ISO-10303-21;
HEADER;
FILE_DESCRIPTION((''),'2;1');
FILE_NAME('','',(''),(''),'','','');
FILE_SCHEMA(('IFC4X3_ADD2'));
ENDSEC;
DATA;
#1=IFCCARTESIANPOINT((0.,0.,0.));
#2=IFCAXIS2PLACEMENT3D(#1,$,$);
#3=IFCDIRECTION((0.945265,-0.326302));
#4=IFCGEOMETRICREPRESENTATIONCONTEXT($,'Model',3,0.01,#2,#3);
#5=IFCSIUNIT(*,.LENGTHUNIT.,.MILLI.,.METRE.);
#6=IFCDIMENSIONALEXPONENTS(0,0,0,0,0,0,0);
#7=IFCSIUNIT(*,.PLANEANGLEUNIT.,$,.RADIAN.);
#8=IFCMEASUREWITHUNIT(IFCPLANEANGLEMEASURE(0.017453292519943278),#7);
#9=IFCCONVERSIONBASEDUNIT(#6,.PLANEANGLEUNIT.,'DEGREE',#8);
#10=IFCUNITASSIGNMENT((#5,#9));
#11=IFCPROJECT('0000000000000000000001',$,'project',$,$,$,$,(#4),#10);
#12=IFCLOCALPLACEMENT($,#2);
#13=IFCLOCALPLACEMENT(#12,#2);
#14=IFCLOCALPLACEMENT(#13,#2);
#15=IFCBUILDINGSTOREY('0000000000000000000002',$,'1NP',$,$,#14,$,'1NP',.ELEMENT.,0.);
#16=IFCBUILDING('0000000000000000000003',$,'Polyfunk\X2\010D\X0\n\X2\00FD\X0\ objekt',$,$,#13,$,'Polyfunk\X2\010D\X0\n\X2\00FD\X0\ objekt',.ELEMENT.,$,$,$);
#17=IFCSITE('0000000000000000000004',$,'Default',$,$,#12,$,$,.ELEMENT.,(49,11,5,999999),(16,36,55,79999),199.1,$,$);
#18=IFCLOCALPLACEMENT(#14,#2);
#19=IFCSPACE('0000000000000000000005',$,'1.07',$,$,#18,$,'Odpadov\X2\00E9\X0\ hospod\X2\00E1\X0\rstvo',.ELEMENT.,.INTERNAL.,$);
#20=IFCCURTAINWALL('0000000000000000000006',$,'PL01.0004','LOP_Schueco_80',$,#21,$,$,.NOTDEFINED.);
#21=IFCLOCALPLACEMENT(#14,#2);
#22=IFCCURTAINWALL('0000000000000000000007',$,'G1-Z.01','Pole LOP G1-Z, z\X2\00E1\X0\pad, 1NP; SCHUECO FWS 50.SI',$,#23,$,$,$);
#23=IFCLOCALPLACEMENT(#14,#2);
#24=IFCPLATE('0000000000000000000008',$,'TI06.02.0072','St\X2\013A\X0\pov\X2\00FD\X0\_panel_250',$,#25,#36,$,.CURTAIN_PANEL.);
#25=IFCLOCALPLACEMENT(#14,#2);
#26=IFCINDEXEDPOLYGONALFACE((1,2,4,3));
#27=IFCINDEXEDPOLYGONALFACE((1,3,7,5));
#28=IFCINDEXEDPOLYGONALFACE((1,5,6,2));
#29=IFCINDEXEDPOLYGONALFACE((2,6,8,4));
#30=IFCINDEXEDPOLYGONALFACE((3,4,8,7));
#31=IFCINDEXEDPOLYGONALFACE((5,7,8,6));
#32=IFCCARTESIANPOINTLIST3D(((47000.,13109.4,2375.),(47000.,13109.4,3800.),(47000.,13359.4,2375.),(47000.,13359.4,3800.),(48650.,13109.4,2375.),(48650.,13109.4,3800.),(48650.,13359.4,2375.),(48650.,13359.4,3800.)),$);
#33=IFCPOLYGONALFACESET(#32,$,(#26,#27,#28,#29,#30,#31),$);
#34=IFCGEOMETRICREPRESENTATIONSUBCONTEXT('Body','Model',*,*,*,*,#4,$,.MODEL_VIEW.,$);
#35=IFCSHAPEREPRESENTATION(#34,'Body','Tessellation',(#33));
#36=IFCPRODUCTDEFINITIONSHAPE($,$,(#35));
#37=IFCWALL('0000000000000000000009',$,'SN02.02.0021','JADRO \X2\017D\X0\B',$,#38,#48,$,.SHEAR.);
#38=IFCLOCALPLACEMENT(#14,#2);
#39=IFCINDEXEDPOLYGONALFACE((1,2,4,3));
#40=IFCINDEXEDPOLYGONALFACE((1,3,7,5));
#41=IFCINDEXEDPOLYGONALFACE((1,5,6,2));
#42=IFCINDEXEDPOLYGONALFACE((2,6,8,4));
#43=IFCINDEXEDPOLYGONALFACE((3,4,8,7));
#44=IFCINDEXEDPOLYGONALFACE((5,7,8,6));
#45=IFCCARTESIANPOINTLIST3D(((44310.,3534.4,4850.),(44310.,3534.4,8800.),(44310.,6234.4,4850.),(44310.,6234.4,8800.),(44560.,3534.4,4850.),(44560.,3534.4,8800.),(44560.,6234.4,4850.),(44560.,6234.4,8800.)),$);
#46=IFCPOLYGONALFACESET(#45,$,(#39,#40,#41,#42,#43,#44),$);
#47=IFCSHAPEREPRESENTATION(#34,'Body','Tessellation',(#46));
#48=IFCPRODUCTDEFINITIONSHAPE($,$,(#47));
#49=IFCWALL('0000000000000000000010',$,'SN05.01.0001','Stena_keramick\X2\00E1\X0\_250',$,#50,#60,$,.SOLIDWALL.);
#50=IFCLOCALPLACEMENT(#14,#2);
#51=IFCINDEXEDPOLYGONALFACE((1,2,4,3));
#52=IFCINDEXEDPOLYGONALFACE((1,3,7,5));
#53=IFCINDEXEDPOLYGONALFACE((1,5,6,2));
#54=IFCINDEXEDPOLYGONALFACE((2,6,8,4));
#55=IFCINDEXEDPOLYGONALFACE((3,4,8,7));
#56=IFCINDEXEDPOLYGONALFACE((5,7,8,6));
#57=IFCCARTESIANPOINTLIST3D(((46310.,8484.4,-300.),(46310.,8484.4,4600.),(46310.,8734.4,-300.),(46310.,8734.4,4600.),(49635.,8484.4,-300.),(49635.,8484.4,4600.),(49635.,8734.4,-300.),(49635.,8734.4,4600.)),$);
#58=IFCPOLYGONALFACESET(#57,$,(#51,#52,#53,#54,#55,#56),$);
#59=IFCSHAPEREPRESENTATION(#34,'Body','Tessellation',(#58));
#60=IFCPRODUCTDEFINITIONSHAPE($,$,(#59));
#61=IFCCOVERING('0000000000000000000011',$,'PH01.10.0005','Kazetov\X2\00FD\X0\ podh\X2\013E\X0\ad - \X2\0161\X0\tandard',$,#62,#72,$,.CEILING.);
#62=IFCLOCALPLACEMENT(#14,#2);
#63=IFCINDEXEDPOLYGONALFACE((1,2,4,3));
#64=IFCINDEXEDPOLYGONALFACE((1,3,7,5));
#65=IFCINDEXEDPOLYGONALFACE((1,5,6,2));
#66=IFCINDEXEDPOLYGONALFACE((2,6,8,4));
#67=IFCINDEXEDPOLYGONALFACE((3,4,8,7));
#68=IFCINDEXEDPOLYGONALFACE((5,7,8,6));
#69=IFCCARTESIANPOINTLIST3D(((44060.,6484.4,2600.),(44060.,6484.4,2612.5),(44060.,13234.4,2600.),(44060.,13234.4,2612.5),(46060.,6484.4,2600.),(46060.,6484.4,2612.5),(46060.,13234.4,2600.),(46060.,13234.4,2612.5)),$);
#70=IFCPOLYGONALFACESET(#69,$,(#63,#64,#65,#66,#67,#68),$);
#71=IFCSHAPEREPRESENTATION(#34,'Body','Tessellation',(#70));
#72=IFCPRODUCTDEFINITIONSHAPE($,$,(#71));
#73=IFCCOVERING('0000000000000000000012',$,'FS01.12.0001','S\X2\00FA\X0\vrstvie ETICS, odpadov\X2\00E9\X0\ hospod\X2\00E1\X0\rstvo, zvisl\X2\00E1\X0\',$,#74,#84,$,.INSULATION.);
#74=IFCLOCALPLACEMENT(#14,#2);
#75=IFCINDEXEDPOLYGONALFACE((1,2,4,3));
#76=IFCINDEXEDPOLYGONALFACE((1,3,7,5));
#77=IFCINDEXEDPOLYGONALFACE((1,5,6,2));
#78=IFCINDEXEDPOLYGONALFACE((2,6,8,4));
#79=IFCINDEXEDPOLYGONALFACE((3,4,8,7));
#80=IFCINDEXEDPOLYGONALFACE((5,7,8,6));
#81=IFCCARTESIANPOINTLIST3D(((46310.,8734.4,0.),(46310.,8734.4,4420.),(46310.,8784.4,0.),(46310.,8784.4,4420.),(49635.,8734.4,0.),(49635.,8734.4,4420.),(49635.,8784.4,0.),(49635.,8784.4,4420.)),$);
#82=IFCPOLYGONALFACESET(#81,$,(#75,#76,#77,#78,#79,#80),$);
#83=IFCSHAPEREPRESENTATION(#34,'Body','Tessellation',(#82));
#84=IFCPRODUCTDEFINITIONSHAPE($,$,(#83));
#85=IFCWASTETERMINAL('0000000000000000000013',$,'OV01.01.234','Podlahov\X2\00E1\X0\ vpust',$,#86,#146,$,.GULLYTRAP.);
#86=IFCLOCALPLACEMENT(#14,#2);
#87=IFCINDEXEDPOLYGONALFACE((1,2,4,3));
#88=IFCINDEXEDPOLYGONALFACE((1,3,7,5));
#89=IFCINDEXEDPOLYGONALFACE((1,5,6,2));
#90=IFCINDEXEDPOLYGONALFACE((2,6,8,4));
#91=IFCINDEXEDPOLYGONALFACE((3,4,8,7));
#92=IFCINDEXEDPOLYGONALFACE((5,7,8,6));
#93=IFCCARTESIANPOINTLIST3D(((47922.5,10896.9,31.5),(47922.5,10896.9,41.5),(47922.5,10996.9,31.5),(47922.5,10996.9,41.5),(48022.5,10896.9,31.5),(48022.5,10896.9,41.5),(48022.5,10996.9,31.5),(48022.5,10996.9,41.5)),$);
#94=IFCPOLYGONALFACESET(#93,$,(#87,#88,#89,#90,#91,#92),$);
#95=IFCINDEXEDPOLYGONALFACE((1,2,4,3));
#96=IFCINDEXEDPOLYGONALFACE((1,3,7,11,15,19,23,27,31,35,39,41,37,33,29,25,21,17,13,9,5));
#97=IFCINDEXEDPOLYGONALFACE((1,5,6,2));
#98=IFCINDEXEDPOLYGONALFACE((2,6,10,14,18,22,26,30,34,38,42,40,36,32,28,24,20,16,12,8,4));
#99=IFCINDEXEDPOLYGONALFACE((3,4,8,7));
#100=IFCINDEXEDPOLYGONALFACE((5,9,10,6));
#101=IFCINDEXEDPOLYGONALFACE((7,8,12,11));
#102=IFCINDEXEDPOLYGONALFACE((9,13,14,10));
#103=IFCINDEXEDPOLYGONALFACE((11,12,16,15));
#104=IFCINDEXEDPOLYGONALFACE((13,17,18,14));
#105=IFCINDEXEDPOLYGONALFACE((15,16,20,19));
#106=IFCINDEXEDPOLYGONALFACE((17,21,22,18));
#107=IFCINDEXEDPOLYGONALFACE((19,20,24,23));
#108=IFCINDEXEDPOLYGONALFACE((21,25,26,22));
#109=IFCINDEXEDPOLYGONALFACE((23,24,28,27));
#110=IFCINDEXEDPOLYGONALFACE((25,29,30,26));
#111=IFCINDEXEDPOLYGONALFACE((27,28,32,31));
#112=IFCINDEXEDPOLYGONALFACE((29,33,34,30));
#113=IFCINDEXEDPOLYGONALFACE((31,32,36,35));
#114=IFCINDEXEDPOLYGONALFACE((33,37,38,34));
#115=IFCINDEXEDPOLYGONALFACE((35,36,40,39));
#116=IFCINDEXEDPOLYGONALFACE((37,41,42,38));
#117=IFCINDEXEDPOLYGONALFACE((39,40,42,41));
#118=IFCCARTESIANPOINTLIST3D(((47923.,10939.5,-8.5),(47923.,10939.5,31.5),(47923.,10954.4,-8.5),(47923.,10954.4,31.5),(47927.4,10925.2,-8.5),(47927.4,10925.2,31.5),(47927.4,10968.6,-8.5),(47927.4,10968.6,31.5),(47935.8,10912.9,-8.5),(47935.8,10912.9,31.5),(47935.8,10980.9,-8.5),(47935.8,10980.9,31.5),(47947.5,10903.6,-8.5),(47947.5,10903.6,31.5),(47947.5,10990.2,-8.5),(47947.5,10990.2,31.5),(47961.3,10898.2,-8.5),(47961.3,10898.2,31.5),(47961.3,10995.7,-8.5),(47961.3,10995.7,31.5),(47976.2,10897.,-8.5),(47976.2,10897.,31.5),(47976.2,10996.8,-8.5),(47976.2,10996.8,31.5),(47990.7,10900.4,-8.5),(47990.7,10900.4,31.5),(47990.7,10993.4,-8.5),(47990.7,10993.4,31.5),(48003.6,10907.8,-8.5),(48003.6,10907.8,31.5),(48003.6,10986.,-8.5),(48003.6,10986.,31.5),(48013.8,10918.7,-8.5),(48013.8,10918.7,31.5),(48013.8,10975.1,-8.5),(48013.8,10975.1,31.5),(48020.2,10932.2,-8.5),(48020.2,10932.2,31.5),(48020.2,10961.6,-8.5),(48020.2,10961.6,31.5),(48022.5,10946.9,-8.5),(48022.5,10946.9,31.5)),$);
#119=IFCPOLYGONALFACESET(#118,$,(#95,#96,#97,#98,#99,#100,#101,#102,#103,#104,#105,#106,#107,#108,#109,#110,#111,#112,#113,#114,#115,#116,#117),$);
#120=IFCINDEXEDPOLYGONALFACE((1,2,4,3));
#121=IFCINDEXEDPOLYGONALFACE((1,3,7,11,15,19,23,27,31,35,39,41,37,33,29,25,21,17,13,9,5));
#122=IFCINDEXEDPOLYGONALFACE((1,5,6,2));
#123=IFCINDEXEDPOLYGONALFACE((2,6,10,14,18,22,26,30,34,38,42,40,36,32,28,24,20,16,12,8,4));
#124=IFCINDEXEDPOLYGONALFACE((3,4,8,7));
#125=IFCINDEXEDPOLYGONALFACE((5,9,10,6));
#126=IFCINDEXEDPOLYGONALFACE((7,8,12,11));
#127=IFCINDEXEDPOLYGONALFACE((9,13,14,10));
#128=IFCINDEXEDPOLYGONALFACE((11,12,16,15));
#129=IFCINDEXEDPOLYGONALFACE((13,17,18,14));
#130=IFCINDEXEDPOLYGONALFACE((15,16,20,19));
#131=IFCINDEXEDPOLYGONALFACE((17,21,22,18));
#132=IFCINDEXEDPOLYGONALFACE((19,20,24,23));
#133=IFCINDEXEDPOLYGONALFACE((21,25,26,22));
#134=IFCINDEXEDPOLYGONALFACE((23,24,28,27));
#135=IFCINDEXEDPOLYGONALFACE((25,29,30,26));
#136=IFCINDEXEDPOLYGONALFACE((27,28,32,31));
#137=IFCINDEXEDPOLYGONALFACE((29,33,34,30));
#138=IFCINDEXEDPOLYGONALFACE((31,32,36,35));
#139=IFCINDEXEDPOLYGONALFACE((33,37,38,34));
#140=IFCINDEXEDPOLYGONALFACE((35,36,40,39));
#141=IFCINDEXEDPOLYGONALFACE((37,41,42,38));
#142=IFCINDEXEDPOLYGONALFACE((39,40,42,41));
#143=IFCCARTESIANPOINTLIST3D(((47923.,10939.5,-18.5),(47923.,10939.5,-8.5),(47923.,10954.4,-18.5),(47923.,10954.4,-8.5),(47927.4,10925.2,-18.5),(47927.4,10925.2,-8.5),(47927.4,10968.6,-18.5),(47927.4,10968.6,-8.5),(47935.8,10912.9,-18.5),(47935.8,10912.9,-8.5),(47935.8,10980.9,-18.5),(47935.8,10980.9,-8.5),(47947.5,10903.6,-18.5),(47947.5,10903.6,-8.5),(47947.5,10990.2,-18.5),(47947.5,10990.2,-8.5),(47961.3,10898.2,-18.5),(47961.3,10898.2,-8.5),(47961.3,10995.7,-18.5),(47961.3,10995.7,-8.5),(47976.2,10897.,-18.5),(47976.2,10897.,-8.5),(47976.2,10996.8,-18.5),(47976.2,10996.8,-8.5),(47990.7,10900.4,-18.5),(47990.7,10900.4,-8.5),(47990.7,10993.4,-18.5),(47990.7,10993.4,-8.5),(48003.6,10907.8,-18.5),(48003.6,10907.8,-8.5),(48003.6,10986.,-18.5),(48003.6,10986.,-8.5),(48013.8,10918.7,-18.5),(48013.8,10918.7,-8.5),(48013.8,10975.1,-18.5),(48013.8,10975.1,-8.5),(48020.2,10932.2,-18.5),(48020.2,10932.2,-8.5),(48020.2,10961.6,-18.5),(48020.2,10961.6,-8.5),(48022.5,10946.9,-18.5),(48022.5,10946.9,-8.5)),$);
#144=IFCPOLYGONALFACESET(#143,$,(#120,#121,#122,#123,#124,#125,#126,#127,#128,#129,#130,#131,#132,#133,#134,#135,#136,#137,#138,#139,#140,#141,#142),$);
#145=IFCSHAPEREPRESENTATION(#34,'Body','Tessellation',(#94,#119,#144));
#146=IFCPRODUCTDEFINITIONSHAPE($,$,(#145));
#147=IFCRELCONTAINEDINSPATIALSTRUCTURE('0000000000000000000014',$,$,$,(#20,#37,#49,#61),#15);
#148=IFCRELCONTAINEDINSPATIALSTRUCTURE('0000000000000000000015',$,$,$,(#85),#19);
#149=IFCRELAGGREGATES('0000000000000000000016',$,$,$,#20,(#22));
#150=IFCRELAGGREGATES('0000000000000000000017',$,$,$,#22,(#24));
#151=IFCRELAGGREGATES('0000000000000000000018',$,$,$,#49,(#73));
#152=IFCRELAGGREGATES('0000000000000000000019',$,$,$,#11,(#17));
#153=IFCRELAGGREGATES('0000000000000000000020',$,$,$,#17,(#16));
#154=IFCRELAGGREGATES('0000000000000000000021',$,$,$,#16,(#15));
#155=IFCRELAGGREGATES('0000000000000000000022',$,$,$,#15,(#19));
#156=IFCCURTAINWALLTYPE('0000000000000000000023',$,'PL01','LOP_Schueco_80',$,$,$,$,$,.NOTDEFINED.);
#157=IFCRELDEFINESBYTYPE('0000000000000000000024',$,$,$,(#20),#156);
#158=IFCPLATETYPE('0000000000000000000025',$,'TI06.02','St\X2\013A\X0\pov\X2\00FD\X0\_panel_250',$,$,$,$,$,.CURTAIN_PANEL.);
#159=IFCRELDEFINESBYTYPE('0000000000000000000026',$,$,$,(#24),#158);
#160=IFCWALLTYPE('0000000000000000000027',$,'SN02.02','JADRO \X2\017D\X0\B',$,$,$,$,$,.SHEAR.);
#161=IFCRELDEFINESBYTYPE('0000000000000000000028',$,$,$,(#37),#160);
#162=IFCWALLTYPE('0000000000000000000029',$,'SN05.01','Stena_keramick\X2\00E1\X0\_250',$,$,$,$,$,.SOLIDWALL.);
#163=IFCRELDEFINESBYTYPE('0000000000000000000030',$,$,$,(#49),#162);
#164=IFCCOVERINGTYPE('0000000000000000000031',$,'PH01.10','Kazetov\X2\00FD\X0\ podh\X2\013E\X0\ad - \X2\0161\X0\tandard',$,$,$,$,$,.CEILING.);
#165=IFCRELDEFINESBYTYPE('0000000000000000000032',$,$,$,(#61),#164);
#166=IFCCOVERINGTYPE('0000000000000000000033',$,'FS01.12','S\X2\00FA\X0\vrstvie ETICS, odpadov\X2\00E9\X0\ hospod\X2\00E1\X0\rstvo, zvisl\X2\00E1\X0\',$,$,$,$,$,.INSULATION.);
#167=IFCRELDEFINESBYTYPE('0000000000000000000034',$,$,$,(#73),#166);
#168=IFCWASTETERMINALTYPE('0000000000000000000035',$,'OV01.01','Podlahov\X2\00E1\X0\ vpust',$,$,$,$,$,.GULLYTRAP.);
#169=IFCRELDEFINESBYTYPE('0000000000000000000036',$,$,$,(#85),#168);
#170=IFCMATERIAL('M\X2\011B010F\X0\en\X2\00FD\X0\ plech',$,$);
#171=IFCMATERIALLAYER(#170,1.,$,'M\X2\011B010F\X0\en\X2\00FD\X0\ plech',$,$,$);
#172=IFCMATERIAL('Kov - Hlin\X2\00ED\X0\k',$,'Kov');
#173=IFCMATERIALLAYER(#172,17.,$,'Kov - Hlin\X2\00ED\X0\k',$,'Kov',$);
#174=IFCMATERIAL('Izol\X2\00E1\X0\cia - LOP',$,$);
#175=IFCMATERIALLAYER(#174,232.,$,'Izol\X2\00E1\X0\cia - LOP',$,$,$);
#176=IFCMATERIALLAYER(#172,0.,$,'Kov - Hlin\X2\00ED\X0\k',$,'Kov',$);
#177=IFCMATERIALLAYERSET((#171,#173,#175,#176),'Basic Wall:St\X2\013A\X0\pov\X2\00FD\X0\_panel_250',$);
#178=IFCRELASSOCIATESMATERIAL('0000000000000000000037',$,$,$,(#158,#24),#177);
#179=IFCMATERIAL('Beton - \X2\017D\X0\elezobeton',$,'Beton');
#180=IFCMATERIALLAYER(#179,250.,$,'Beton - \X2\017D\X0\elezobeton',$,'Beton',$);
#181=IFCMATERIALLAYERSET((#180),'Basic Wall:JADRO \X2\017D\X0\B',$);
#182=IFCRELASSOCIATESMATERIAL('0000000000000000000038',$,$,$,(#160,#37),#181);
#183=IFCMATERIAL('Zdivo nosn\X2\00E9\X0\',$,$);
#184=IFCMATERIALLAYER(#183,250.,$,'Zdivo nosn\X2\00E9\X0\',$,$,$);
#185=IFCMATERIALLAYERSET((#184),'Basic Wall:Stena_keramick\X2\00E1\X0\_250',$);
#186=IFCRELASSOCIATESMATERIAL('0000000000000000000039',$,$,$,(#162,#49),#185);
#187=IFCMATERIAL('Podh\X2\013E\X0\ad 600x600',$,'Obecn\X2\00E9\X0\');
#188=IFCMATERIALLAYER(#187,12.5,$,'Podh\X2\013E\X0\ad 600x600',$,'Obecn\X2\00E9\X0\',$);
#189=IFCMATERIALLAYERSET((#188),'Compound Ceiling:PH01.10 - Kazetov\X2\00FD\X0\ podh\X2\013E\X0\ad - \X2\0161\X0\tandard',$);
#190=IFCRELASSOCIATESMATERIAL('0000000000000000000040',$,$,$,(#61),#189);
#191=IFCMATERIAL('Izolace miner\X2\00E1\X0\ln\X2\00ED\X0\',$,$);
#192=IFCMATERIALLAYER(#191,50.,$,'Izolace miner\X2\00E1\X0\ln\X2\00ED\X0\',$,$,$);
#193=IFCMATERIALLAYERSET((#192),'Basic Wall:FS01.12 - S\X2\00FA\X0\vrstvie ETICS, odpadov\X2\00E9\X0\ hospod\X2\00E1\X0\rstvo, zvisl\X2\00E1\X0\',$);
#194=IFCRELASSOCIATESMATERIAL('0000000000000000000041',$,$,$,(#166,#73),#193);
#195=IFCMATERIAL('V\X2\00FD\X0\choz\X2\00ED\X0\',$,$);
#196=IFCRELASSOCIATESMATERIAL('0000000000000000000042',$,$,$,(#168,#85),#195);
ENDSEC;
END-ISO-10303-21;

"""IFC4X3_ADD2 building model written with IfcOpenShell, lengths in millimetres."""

from ifc_helpers import new_model, entity, si_unit, converted_unit, direction, frame, frame_2d, origin, place, context, subcontext, project, spatial, polyline, rectangle, circle, extrude, clip, bounded_halfspace, source, transform, mapped, material, layer, layer_set, layer_usage, type_object, type_shapes, element, aggregate, save


model = new_model("IFC4X3_ADD2")

# Units and contexts
model_context = context("Model", 3, precision=0.01, world=origin(), true_north=direction((0.945265, -0.326302)))
body_context = subcontext(model_context, "Body", "Model", "MODEL_VIEW")
ifc_project = project(units=[si_unit("LENGTHUNIT", "METRE", prefix="MILLI"), converted_unit("PLANEANGLEUNIT", "DEGREE", entity("IfcPlaneAngleMeasure", 0.017453292519943278), si_unit("PLANEANGLEUNIT", "RADIAN"), dimensions=[0, 0, 0, 0, 0, 0, 0])], contexts=[model_context])

# Site, building, storey
site_placement = place(None, origin())
site = spatial("IfcSite", under=ifc_project, at=site_placement, Name="Default", CompositionType="ELEMENT", RefLatitude=(49, 11, 5, 999999), RefLongitude=(16, 36, 55, 79999), RefElevation=199.1)
building_placement = place(site_placement, origin())
building = spatial("IfcBuilding", under=site, at=building_placement, Name="Polyfunkčný objekt", LongName="Polyfunkčný objekt", CompositionType="ELEMENT")
storey_placement = place(building_placement, origin())
storey = spatial("IfcBuildingStorey", under=building, at=storey_placement, Name="1NP", LongName="1NP", CompositionType="ELEMENT", Elevation=0.0)

# Curtain walls, plate
curtain_wall_type = type_object("IfcCurtainWallType", Name="PL01", Description="LOP_Schueco_80", PredefinedType="NOTDEFINED")
curtain_wall_1_placement = place(storey_placement, origin())
curtain_wall_1 = element("IfcCurtainWall", 1, at=curtain_wall_1_placement, inside=storey, type_object=curtain_wall_type, Name="PL01.0004", Description="LOP_Schueco_80", PredefinedType="NOTDEFINED")
curtain_wall_2 = element("IfcCurtainWall", 2, Name="G1-Z.01", Description="Pole LOP G1-Z, západ, 1NP; SCHUECO FWS 50.SI")
aggregate(curtain_wall_1, [curtain_wall_2])
ifc_material_1 = material(Name="Měďený plech")
ifc_layer_1 = layer(ifc_material_1, 1.0, Name="Měďený plech")
ifc_material_2 = material(Name="Kov - Hliník", Category="Kov")
ifc_layer_2 = layer(ifc_material_2, 17.0, Name="Kov - Hliník", Category="Kov")
ifc_material_3 = material(Name="Izolácia - LOP")
ifc_layer_3 = layer(ifc_material_3, 232.0, Name="Izolácia - LOP")
ifc_layer_4 = layer(ifc_material_2, 0.0, Name="Kov - Hliník", Category="Kov")
ifc_layer_set_1 = layer_set([ifc_layer_1, ifc_layer_2, ifc_layer_3, ifc_layer_4], Name="Basic Wall:Stĺpový_panel_250")
ifc_layer_usage_1 = layer_usage(ifc_layer_set_1, "AXIS2", "NEGATIVE", 125.0)
plate_type = type_object("IfcPlateType", Name="TI06.02", Description="Stĺpový_panel_250", PredefinedType="CURTAIN_PANEL", material=ifc_layer_set_1)
plate_placement = place(storey_placement, frame((47000.0, 13234.4, 2375.0)))
plate = element("IfcPlate", 3, at=plate_placement, type_object=plate_type, material=ifc_layer_usage_1, Name="TI06.02.0072", Description="Stĺpový_panel_250", PredefinedType="CURTAIN_PANEL", context=body_context, shape_type="SweptSolid", body=[
    extrude(rectangle(XDim=250.0, YDim=1650.0, at=frame_2d((0.0, 0.0), x_axis=(1.0, 0.0))), frame((825.0, 0.0, 0.0), z_axis=(0.0, 0.0, 1.0), x_axis=(0.0, 1.0, 0.0)), (0.0, 0.0, 1.0), 1425.0),
])
aggregate(curtain_wall_2, [plate])

# Wall
ifc_material_4 = material(Name="Beton - Železobeton", Category="Beton")
ifc_layer_5 = layer(ifc_material_4, 250.0, Name="Beton - Železobeton", Category="Beton")
ifc_layer_set_2 = layer_set([ifc_layer_5], Name="Basic Wall:JADRO ŽB")
wall_type_1 = type_object("IfcWallType", Name="SN02.02", Description="JADRO ŽB", PredefinedType="SHEAR", material=ifc_layer_set_2)
wall_1_placement = place(storey_placement, frame((44435.0, 6234.4, 4850.0), z_axis=(0.0, 0.0, 1.0), x_axis=(0.0, -1.0, 0.0)))
element("IfcWall", 4, at=wall_1_placement, inside=storey, type_object=wall_type_1, material=ifc_layer_set_2, Name="SN02.02.0021", Description="JADRO ŽB", PredefinedType="SHEAR", context=body_context, shape_type="Clipping", body=[
    clip(clip(extrude(rectangle(XDim=2700.0, YDim=250.0, at=frame_2d((1350.0, 0.0), x_axis=(-1.0, 0.0))), origin(), (0.0, 0.0, 1.0), 3950.0), bounded_halfspace(frame((2700.0, -125.0, 0.0), z_axis=(0.0, 0.0, 1.0), x_axis=(0.0, -1.0, 0.0)), True, frame((2700.0, -125.0, 0.0)), polyline([(0.0, 0.0), (0.0, 250.0), (-2700.0, 250.0), (-2700.0, 0.0), (0.0, 0.0)]))), bounded_halfspace(frame((0.0, -125.0, 3950.0), z_axis=(0.0, 0.0, -1.0), x_axis=(0.0, 1.0, 0.0)), True, frame((0.0, -125.0, 3950.0)), polyline([(0.0, 0.0), (2700.0, 0.0), (2700.0, 250.0), (0.0, 250.0), (0.0, 0.0)]))),
])

# Wall
ifc_material_5 = material(Name="Zdivo nosné")
ifc_layer_6 = layer(ifc_material_5, 250.0, Name="Zdivo nosné")
ifc_layer_set_3 = layer_set([ifc_layer_6], Name="Basic Wall:Stena_keramická_250")
wall_type_2 = type_object("IfcWallType", Name="SN05.01", Description="Stena_keramická_250", PredefinedType="SOLIDWALL", material=ifc_layer_set_3)
wall_2_placement = place(storey_placement, frame((46310.0, 8609.4, -300.0)))
wall_2 = element("IfcWall", 5, at=wall_2_placement, inside=storey, type_object=wall_type_2, material=ifc_layer_set_3, Name="SN05.01.0001", Description="Stena_keramická_250", PredefinedType="SOLIDWALL", context=body_context, shape_type="Clipping", body=[
    clip(clip(extrude(rectangle(XDim=3325.0, YDim=250.0, at=frame_2d((1662.5, 0.0), x_axis=(-1.0, 0.0))), origin(), (0.0, 0.0, 1.0), 4900.0), bounded_halfspace(frame((0.0, -125.0, 4900.0), z_axis=(0.0, 0.0, -1.0), x_axis=(1.0, 0.0, 0.0)), True, frame((0.0, -125.0, 4900.0)), polyline([(0.0, 0.0), (3325.0, 0.0), (3325.0, 250.0), (0.0, 250.0), (0.0, 0.0)]))), bounded_halfspace(frame((3325.0, -125.0, 0.0), z_axis=(0.0, 0.0, 1.0), x_axis=(0.0, 1.0, 0.0)), True, frame((3325.0, -125.0, 0.0)), polyline([(0.0, 0.0), (0.0, 250.0), (-3325.0, 250.0), (-3325.0, 0.0), (0.0, 0.0)]))),
])

# Coverings
ifc_material_6 = material(Name="Podhľad 600x600", Category="Obecné")
ifc_layer_7 = layer(ifc_material_6, 12.5, Name="Podhľad 600x600", Category="Obecné")
ifc_layer_set_4 = layer_set([ifc_layer_7], Name="Compound Ceiling:PH01.10 - Kazetový podhľad - štandard")
ifc_layer_usage_2 = layer_usage(ifc_layer_set_4, "AXIS3", "NEGATIVE", 0.0)
covering_type_1 = type_object("IfcCoveringType", Name="PH01.10", Description="Kazetový podhľad - štandard", PredefinedType="CEILING")
covering_1_placement = place(storey_placement, frame((44060.0, 6484.4, 2600.0)))
element("IfcCovering", 6, at=covering_1_placement, inside=storey, type_object=covering_type_1, material=ifc_layer_usage_2, Name="PH01.10.0005", Description="Kazetový podhľad - štandard", PredefinedType="CEILING", context=body_context, shape_type="SweptSolid", body=[
    extrude(rectangle(XDim=2000.0, YDim=6750.0, at=frame_2d((0.0, 0.0), x_axis=(1.0, 0.0))), frame((1000.0, 3375.0, 0.0), z_axis=(0.0, 0.0, 1.0), x_axis=(-1.0, 0.0, 0.0)), (0.0, 0.0, 1.0), 12.5),
])
ifc_material_7 = material(Name="Izolace minerální")
ifc_layer_8 = layer(ifc_material_7, 50.0, Name="Izolace minerální")
ifc_layer_set_5 = layer_set([ifc_layer_8], Name="Basic Wall:FS01.12 - Súvrstvie ETICS, odpadové hospodárstvo, zvislá")
covering_type_2 = type_object("IfcCoveringType", Name="FS01.12", Description="Súvrstvie ETICS, odpadové hospodárstvo, zvislá", PredefinedType="INSULATION", material=ifc_layer_set_5)
covering_2_placement = place(storey_placement, frame((46310.0, 8759.4, 0.0)))
covering_2 = element("IfcCovering", 7, at=covering_2_placement, type_object=covering_type_2, material=ifc_layer_set_5, Name="FS01.12.0001", Description="Súvrstvie ETICS, odpadové hospodárstvo, zvislá", PredefinedType="INSULATION", context=body_context, shape_type="SweptSolid", body=[
    extrude(rectangle(XDim=3325.0, YDim=50.0, at=frame_2d((1662.5, 0.0), x_axis=(-1.0, 0.0))), origin(), (0.0, 0.0, 1.0), 4420.0),
])
aggregate(wall_2, [covering_2])

# Shared definitions
space_placement = place(storey_placement, origin())
space = spatial("IfcSpace", under=storey, at=space_placement, Name="1.07", LongName="Odpadové hospodárstvo", CompositionType="ELEMENT", PredefinedType="INTERNAL")

# Waste terminal
ifc_material_8 = material(Name="Výchozí")
waste_terminal_type = type_object("IfcWasteTerminalType", Name="OV01.01", Description="Podlahová vpust", PredefinedType="GULLYTRAP", material=ifc_material_8)
shared_shape_1 = source(origin(), body_context, "Body", "SweptSolid", [
    extrude(rectangle(XDim=100.0, YDim=100.0, at=frame_2d((0.0, 0.0), x_axis=(1.0, 0.0))), frame((0.0, 0.0, -10.0), z_axis=(0.0, 0.0, 1.0), x_axis=(-1.0, 0.0, 0.0)), (0.0, 0.0, 1.0), 10.0),
    extrude(circle(Radius=50.0, at=frame_2d((0.0, 0.0), x_axis=(1.0, 0.0))), frame((0.0, 0.0, -50.0)), (0.0, 0.0, 1.0), 40.0),
    extrude(circle(Radius=50.0, at=frame_2d((0.0, 0.0), x_axis=(1.0, 0.0))), frame((0.0, 0.0, -60.0)), (0.0, 0.0, 1.0), 10.0),
])
type_shapes(waste_terminal_type, [shared_shape_1])
waste_terminal_placement = place(storey_placement, frame((47972.5, 10946.9, 41.5)))
element("IfcWasteTerminal", 8, at=waste_terminal_placement, inside=space, type_object=waste_terminal_type, material=ifc_material_8, Name="OV01.01.234", Description="Podlahová vpust", PredefinedType="GULLYTRAP", context=body_context, shape_type="MappedRepresentation", body=[
    mapped(shared_shape_1, transform((0.0, 0.0, 0.0), scale=1.0)),
])

save(model, "model.ifc")
